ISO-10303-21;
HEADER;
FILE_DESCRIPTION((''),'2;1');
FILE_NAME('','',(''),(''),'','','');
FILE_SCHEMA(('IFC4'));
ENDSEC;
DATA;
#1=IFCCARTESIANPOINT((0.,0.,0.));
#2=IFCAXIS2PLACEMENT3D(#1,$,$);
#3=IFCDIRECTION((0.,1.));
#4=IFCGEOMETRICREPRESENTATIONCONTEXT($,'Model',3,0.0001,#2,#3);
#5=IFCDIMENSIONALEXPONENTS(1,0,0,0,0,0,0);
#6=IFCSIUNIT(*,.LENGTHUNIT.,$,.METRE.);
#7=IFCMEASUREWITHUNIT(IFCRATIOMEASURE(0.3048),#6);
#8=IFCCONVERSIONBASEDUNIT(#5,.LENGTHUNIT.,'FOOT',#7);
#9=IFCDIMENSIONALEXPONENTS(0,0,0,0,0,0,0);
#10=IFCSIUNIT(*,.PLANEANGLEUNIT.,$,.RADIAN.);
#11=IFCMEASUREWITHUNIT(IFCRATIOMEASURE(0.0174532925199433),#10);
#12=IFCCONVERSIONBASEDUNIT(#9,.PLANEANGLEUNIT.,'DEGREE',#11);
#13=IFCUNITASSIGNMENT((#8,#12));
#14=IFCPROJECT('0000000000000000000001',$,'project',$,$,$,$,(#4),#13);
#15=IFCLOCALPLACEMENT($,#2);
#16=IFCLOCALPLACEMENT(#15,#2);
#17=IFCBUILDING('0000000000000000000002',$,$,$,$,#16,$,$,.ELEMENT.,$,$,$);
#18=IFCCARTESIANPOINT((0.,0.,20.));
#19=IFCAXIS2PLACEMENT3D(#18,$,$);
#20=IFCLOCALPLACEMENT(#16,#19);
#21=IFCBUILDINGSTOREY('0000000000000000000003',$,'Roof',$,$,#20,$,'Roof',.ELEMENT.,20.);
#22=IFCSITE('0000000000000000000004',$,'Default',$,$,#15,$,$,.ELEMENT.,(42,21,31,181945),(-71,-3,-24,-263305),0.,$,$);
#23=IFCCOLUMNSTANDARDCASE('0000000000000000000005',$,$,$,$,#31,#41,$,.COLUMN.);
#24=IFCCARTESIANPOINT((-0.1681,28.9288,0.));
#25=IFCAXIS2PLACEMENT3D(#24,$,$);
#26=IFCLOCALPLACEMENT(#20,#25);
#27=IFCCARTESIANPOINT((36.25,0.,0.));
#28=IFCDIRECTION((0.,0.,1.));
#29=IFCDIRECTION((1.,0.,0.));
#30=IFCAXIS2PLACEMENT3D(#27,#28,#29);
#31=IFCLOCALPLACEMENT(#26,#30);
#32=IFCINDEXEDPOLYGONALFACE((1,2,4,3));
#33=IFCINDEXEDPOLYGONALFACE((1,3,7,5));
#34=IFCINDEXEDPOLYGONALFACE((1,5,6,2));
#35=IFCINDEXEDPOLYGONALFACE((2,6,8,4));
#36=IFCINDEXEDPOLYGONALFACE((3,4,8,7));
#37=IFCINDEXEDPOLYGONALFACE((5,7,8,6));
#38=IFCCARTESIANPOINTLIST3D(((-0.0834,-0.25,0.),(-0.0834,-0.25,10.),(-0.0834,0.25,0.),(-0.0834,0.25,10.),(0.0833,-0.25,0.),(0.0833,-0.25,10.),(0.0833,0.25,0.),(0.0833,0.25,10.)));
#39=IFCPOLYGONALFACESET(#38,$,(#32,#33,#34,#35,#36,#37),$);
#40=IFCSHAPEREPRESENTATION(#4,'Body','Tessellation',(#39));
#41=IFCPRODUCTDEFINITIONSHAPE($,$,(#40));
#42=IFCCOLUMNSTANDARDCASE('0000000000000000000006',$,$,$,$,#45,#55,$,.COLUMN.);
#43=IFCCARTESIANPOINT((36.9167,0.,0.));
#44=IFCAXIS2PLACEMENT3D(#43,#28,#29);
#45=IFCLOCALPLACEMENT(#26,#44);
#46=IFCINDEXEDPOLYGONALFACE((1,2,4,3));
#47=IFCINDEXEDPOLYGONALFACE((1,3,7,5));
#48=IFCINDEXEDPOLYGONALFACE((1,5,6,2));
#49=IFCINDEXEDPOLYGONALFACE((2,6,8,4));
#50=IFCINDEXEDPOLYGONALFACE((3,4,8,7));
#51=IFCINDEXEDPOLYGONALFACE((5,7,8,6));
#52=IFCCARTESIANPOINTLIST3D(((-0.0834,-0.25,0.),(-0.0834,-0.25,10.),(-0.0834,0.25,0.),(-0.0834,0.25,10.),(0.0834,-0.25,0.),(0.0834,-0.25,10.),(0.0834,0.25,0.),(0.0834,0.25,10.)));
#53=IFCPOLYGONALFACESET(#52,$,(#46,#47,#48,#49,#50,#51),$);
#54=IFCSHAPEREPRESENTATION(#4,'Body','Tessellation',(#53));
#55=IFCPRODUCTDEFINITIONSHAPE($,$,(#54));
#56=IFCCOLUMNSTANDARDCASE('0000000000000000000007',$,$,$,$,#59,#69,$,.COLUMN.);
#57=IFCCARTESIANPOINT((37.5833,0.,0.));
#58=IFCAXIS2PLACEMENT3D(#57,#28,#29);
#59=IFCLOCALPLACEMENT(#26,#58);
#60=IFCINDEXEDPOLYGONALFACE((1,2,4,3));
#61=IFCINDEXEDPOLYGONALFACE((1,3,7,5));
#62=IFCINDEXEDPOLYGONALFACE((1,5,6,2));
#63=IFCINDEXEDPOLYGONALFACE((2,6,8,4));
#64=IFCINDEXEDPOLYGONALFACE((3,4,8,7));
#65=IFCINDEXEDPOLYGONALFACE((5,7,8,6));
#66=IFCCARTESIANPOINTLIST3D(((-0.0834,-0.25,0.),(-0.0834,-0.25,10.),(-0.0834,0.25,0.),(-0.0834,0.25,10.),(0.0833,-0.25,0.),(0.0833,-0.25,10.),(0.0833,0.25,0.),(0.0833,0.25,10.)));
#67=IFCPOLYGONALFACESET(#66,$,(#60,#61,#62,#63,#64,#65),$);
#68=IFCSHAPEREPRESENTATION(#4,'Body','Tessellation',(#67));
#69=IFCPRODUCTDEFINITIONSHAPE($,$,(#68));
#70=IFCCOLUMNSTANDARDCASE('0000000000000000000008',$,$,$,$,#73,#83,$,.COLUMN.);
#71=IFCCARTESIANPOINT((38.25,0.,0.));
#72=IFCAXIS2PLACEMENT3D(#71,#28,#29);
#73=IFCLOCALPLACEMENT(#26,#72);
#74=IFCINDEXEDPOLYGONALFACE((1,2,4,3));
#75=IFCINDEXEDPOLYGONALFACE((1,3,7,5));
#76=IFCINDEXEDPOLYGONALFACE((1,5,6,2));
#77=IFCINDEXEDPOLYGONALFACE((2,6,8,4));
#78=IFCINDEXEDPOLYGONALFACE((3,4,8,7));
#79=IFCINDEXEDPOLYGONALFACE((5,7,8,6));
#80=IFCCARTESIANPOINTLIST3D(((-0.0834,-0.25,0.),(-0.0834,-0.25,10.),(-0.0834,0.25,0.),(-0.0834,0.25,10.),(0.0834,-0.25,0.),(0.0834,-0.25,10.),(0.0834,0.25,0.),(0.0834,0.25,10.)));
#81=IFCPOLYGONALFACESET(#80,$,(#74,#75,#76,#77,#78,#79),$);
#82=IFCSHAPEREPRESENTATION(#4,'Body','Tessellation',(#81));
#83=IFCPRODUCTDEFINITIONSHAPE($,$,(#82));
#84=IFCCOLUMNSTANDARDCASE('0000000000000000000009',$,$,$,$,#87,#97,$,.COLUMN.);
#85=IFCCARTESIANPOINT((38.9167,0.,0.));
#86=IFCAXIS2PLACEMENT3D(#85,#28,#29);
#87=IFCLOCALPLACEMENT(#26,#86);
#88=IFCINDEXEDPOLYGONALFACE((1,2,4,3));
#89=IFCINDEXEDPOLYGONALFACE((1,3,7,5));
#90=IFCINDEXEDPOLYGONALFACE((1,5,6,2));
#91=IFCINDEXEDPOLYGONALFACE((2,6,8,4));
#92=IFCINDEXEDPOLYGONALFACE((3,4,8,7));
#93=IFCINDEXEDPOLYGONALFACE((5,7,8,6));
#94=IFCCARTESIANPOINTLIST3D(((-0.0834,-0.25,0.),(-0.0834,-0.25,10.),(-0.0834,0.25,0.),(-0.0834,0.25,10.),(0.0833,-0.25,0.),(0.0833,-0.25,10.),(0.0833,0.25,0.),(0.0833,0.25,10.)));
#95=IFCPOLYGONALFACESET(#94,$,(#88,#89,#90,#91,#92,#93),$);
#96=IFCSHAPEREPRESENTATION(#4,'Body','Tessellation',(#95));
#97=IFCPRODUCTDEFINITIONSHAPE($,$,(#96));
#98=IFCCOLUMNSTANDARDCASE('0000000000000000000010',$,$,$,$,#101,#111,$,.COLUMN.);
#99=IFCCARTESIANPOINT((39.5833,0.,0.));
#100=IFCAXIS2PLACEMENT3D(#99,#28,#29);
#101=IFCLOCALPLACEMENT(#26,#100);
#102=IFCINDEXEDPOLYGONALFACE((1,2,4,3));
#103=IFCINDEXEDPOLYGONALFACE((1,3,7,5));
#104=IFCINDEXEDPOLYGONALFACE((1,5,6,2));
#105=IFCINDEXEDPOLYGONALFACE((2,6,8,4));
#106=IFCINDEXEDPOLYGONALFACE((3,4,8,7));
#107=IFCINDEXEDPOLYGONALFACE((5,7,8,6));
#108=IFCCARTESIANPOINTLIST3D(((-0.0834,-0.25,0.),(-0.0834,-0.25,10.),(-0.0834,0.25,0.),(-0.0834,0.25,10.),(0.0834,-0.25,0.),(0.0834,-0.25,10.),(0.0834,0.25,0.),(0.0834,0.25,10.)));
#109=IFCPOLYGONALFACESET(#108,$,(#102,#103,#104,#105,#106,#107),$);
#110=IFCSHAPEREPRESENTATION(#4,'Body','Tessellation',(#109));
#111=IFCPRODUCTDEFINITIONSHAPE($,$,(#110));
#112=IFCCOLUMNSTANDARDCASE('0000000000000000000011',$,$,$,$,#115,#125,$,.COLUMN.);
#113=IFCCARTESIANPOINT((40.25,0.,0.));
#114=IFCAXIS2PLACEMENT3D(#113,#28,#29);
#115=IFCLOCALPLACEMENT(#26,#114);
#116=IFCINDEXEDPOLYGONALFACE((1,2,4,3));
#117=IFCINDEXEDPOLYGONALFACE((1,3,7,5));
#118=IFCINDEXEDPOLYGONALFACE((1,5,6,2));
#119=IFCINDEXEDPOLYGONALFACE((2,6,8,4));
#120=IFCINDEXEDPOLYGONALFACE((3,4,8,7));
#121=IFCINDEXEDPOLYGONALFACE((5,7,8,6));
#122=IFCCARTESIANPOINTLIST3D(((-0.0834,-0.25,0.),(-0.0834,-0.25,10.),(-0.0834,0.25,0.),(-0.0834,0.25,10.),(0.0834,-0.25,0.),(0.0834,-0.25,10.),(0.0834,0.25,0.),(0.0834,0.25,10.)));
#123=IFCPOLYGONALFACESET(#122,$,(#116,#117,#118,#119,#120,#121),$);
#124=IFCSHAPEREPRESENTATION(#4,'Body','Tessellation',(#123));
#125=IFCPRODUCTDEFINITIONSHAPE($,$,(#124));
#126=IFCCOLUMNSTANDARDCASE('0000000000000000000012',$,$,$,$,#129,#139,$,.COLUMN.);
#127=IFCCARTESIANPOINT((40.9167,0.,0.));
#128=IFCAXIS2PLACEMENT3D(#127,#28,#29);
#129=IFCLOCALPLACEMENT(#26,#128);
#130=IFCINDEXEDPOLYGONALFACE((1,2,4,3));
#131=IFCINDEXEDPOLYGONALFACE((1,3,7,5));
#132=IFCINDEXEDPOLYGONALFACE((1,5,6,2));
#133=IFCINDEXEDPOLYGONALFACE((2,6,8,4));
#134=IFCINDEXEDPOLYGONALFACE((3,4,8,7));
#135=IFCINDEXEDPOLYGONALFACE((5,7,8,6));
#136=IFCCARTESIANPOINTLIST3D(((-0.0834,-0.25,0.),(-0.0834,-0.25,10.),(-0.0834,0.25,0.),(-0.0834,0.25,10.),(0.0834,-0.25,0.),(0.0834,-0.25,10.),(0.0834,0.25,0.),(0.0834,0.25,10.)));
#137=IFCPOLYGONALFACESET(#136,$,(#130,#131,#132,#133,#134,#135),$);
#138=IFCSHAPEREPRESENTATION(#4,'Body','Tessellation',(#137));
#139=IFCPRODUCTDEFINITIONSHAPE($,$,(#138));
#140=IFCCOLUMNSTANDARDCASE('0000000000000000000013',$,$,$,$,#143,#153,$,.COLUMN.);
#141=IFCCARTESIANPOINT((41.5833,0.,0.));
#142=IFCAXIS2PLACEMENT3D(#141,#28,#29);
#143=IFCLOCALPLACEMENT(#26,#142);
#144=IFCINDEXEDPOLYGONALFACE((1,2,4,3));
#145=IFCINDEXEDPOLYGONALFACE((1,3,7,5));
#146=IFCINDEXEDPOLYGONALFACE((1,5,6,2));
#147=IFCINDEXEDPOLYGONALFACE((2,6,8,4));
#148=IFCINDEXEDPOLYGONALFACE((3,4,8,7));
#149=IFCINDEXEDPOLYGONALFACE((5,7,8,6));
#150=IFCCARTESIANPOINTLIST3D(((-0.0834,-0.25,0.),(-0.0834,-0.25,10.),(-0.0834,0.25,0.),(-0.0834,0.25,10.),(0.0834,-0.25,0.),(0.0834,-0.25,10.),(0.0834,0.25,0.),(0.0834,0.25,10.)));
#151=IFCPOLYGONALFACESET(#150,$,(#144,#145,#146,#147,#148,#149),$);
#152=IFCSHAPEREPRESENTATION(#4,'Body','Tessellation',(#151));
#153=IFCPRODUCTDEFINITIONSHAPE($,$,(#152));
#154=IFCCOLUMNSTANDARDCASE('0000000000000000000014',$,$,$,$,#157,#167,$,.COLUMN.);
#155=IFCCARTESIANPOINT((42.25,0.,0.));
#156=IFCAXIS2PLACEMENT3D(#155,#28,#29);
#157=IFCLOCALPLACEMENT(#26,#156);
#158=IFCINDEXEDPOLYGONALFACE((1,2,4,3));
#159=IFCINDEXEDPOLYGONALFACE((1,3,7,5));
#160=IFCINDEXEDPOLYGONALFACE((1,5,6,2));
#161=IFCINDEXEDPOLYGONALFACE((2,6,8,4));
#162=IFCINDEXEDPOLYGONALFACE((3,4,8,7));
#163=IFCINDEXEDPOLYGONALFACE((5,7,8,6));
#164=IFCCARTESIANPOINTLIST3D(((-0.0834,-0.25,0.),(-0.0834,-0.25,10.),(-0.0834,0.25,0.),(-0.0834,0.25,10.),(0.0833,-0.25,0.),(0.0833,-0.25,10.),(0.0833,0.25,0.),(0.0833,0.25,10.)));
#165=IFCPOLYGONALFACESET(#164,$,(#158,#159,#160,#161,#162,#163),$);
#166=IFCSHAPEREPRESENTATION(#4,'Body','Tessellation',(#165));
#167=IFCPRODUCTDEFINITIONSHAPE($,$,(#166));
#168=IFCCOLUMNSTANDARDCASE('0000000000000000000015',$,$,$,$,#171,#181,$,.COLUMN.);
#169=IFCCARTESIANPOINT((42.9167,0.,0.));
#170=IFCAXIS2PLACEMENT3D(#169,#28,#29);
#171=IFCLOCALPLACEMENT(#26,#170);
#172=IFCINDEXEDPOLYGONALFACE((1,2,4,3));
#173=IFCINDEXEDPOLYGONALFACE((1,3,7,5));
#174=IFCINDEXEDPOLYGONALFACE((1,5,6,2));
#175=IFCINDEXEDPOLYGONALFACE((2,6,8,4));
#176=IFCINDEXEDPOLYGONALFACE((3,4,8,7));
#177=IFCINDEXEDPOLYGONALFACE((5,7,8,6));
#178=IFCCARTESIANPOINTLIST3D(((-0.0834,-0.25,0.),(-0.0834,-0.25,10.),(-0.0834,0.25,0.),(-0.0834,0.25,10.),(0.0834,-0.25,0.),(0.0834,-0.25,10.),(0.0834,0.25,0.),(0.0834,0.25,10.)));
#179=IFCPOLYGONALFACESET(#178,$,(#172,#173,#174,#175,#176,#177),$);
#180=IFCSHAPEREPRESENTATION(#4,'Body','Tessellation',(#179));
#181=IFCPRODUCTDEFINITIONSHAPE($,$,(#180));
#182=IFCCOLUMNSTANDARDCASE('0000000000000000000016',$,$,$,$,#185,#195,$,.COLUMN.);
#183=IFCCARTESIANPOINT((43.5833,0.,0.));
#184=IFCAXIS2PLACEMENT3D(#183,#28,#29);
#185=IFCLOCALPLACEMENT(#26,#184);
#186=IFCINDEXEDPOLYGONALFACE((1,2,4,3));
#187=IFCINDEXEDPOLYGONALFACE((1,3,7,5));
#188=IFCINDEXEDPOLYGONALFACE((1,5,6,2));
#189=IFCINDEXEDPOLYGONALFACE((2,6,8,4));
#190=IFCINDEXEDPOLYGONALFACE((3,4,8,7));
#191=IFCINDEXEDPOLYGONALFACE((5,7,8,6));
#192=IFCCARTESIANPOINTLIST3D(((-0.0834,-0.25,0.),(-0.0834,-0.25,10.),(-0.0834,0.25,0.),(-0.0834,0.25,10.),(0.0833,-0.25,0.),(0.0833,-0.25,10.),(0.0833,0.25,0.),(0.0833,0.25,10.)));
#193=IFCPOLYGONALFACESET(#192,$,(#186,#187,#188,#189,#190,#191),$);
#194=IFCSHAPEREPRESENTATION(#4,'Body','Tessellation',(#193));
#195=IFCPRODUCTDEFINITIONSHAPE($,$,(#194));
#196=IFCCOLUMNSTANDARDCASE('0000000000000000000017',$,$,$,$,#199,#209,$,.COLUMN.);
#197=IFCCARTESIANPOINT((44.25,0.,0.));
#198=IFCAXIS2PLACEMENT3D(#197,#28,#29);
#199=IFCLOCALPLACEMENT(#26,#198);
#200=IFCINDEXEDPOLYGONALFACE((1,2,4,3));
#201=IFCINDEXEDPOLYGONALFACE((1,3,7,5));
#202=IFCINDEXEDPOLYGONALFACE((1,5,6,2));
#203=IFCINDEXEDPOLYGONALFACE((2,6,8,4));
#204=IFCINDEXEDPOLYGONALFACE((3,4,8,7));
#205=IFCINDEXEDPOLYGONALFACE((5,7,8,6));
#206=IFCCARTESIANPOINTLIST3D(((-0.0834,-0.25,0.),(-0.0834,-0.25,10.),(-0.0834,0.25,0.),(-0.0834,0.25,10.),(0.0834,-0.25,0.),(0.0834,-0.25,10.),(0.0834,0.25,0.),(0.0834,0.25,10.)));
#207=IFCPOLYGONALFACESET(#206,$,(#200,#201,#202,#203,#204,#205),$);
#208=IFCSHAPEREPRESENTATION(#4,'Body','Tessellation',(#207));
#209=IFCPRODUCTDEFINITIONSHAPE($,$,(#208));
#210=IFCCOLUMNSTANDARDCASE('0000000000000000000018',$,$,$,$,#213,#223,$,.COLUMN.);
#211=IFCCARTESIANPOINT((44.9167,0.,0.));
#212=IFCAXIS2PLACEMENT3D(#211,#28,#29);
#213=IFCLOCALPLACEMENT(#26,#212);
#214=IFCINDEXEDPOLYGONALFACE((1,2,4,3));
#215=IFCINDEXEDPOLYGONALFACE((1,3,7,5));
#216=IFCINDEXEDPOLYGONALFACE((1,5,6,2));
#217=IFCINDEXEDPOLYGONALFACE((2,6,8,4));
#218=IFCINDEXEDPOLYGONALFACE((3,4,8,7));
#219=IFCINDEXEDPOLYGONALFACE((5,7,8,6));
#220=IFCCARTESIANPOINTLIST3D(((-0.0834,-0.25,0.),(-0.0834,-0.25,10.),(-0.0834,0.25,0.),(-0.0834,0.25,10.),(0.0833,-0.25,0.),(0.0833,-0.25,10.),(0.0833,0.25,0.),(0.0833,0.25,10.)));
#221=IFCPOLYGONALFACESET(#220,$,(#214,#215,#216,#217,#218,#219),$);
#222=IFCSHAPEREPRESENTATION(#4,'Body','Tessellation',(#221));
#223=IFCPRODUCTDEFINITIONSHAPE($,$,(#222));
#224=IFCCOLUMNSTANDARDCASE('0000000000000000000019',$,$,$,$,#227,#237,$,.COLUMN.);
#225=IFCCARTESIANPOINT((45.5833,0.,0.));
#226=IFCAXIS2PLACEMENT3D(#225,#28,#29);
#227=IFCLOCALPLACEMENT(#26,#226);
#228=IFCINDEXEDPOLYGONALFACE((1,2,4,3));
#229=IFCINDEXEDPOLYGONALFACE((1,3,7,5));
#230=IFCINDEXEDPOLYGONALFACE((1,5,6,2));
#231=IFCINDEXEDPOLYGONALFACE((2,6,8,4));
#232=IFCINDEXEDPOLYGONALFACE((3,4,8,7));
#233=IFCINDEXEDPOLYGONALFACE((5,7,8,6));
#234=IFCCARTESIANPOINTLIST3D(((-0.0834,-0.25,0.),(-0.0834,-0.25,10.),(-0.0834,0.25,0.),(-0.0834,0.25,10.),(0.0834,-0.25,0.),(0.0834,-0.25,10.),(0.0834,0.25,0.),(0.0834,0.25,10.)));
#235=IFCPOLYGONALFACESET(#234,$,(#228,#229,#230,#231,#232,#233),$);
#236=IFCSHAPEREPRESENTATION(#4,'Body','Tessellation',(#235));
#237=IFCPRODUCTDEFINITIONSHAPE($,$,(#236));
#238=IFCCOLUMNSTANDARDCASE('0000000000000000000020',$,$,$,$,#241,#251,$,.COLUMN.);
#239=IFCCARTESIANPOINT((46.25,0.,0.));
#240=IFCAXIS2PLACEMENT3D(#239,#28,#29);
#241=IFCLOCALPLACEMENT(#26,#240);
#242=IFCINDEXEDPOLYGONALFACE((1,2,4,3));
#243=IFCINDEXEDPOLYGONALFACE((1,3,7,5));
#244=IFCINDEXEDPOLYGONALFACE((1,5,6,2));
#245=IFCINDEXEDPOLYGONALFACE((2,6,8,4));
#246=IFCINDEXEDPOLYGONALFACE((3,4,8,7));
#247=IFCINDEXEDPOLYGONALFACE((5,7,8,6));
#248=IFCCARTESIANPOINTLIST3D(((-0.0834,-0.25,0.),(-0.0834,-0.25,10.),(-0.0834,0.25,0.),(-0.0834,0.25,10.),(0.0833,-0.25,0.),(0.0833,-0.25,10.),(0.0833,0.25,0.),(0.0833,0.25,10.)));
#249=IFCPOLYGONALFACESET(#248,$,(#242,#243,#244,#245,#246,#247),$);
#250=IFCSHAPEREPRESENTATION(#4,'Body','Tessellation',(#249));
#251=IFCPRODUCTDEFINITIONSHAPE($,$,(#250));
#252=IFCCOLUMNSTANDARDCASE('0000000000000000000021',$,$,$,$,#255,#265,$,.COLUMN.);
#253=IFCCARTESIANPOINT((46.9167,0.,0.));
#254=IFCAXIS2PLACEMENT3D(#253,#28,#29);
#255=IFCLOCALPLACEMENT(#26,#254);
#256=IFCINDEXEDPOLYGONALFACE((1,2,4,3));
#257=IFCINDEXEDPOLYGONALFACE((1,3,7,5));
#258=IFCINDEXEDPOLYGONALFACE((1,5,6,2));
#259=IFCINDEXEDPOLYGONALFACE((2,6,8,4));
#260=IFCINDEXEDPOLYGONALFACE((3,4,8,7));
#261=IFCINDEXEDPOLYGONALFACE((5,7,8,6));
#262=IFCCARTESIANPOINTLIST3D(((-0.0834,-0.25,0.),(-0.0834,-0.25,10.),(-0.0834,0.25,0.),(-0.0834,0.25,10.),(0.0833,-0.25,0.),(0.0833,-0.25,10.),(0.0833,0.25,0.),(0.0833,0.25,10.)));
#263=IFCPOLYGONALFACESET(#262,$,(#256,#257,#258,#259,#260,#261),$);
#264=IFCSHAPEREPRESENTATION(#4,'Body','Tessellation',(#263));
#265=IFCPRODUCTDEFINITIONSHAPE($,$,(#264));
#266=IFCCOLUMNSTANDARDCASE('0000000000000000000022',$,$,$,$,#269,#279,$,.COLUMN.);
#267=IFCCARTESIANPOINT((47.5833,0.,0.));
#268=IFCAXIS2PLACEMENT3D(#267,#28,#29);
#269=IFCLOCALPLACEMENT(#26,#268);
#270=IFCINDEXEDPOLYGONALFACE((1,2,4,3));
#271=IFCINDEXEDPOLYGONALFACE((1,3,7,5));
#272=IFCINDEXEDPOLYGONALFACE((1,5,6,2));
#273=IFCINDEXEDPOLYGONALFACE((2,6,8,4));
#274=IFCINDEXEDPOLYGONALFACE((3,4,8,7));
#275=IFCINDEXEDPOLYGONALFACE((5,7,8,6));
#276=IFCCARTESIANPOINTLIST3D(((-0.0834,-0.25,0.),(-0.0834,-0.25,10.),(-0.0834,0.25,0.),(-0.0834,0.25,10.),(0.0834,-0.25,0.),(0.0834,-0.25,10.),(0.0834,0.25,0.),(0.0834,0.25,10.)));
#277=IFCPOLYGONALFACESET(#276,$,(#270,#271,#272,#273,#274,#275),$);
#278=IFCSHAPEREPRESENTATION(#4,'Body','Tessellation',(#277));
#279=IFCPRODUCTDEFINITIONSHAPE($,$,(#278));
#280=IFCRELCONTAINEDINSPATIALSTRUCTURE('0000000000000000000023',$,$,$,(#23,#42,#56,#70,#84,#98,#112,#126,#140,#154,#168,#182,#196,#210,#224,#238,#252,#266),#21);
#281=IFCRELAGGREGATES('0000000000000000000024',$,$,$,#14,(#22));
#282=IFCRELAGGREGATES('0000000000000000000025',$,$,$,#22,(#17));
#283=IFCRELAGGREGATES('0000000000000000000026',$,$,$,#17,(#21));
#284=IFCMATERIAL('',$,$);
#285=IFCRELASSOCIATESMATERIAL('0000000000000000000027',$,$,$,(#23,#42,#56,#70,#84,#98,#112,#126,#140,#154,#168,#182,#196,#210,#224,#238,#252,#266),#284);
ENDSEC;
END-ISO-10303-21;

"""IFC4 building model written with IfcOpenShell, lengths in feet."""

from ifc_helpers import new_model, entity, si_unit, converted_unit, direction, frame, origin, place, context, project, spatial, rectangle, extrude, material, element, save


model = new_model("IFC4")

# Units and contexts
model_context = context("Model", 3, precision=0.0001, world=origin(), true_north=direction((0.0, 1.0)))
ifc_project = project(units=[converted_unit("LENGTHUNIT", "FOOT", entity("IfcRatioMeasure", 0.3048), si_unit("LENGTHUNIT", "METRE"), dimensions=[1, 0, 0, 0, 0, 0, 0]), converted_unit("PLANEANGLEUNIT", "DEGREE", entity("IfcRatioMeasure", 0.0174532925199433), si_unit("PLANEANGLEUNIT", "RADIAN"), dimensions=[0, 0, 0, 0, 0, 0, 0])], contexts=[model_context])

# Site, building, storey
site_placement = place(None, origin())
site = spatial("IfcSite", under=ifc_project, at=site_placement, Name="Default", CompositionType="ELEMENT", RefLatitude=(42, 21, 31, 181945), RefLongitude=(-71, -3, -24, -263305), RefElevation=0.0)
building_placement = place(site_placement, origin())
building = spatial("IfcBuilding", under=site, at=building_placement, CompositionType="ELEMENT")
storey_placement = place(building_placement, frame((0.0, 0.0, 20.0)))
storey = spatial("IfcBuildingStorey", under=building, at=storey_placement, Name="Roof", LongName="Roof", CompositionType="ELEMENT", Elevation=20.0)

# Columns
ifc_material_1 = material(Name="")
placement = place(storey_placement, frame((-0.1681, 28.9288, 0.0)))
for number, where, z_axis, x_axis in (
    (1, (36.25, 0.0, 0.0), (0.0, 0.0, 1.0), (1.0, 0.0, 0.0)),
    (2, (36.9167, 0.0, 0.0), (0.0, 0.0, 1.0), (1.0, 0.0, 0.0)),
    (3, (37.5833, 0.0, 0.0), (0.0, 0.0, 1.0), (1.0, 0.0, 0.0)),
    (4, (38.25, 0.0, 0.0), (0.0, 0.0, 1.0), (1.0, 0.0, 0.0)),
    (5, (38.9167, 0.0, 0.0), (0.0, 0.0, 1.0), (1.0, 0.0, 0.0)),
    (6, (39.5833, 0.0, 0.0), (0.0, 0.0, 1.0), (1.0, 0.0, 0.0)),
    (7, (40.25, 0.0, 0.0), (0.0, 0.0, 1.0), (1.0, 0.0, 0.0)),
    (8, (40.9167, 0.0, 0.0), (0.0, 0.0, 1.0), (1.0, 0.0, 0.0)),
    (9, (41.5833, 0.0, 0.0), (0.0, 0.0, 1.0), (1.0, 0.0, 0.0)),
    (10, (42.25, 0.0, 0.0), (0.0, 0.0, 1.0), (1.0, 0.0, 0.0)),
    (11, (42.9167, 0.0, 0.0), (0.0, 0.0, 1.0), (1.0, 0.0, 0.0)),
    (12, (43.5833, 0.0, 0.0), (0.0, 0.0, 1.0), (1.0, 0.0, 0.0)),
    (13, (44.25, 0.0, 0.0), (0.0, 0.0, 1.0), (1.0, 0.0, 0.0)),
    (14, (44.9167, 0.0, 0.0), (0.0, 0.0, 1.0), (1.0, 0.0, 0.0)),
    (15, (45.5833, 0.0, 0.0), (0.0, 0.0, 1.0), (1.0, 0.0, 0.0)),
    (16, (46.25, 0.0, 0.0), (0.0, 0.0, 1.0), (1.0, 0.0, 0.0)),
    (17, (46.9167, 0.0, 0.0), (0.0, 0.0, 1.0), (1.0, 0.0, 0.0)),
    (18, (47.5833, 0.0, 0.0), (0.0, 0.0, 1.0), (1.0, 0.0, 0.0)),
):
    element("IfcColumnStandardCase", number, at=place(placement, frame(where, z_axis=z_axis, x_axis=x_axis)), inside=storey, material=ifc_material_1, PredefinedType="COLUMN", context=model_context, shape_type="SweptSolid", body=[
        extrude(rectangle(XDim=0.1667, YDim=0.5), origin(), (0.0, 0.0, 1.0), 10.0),
    ])

save(model, "model.ifc")
